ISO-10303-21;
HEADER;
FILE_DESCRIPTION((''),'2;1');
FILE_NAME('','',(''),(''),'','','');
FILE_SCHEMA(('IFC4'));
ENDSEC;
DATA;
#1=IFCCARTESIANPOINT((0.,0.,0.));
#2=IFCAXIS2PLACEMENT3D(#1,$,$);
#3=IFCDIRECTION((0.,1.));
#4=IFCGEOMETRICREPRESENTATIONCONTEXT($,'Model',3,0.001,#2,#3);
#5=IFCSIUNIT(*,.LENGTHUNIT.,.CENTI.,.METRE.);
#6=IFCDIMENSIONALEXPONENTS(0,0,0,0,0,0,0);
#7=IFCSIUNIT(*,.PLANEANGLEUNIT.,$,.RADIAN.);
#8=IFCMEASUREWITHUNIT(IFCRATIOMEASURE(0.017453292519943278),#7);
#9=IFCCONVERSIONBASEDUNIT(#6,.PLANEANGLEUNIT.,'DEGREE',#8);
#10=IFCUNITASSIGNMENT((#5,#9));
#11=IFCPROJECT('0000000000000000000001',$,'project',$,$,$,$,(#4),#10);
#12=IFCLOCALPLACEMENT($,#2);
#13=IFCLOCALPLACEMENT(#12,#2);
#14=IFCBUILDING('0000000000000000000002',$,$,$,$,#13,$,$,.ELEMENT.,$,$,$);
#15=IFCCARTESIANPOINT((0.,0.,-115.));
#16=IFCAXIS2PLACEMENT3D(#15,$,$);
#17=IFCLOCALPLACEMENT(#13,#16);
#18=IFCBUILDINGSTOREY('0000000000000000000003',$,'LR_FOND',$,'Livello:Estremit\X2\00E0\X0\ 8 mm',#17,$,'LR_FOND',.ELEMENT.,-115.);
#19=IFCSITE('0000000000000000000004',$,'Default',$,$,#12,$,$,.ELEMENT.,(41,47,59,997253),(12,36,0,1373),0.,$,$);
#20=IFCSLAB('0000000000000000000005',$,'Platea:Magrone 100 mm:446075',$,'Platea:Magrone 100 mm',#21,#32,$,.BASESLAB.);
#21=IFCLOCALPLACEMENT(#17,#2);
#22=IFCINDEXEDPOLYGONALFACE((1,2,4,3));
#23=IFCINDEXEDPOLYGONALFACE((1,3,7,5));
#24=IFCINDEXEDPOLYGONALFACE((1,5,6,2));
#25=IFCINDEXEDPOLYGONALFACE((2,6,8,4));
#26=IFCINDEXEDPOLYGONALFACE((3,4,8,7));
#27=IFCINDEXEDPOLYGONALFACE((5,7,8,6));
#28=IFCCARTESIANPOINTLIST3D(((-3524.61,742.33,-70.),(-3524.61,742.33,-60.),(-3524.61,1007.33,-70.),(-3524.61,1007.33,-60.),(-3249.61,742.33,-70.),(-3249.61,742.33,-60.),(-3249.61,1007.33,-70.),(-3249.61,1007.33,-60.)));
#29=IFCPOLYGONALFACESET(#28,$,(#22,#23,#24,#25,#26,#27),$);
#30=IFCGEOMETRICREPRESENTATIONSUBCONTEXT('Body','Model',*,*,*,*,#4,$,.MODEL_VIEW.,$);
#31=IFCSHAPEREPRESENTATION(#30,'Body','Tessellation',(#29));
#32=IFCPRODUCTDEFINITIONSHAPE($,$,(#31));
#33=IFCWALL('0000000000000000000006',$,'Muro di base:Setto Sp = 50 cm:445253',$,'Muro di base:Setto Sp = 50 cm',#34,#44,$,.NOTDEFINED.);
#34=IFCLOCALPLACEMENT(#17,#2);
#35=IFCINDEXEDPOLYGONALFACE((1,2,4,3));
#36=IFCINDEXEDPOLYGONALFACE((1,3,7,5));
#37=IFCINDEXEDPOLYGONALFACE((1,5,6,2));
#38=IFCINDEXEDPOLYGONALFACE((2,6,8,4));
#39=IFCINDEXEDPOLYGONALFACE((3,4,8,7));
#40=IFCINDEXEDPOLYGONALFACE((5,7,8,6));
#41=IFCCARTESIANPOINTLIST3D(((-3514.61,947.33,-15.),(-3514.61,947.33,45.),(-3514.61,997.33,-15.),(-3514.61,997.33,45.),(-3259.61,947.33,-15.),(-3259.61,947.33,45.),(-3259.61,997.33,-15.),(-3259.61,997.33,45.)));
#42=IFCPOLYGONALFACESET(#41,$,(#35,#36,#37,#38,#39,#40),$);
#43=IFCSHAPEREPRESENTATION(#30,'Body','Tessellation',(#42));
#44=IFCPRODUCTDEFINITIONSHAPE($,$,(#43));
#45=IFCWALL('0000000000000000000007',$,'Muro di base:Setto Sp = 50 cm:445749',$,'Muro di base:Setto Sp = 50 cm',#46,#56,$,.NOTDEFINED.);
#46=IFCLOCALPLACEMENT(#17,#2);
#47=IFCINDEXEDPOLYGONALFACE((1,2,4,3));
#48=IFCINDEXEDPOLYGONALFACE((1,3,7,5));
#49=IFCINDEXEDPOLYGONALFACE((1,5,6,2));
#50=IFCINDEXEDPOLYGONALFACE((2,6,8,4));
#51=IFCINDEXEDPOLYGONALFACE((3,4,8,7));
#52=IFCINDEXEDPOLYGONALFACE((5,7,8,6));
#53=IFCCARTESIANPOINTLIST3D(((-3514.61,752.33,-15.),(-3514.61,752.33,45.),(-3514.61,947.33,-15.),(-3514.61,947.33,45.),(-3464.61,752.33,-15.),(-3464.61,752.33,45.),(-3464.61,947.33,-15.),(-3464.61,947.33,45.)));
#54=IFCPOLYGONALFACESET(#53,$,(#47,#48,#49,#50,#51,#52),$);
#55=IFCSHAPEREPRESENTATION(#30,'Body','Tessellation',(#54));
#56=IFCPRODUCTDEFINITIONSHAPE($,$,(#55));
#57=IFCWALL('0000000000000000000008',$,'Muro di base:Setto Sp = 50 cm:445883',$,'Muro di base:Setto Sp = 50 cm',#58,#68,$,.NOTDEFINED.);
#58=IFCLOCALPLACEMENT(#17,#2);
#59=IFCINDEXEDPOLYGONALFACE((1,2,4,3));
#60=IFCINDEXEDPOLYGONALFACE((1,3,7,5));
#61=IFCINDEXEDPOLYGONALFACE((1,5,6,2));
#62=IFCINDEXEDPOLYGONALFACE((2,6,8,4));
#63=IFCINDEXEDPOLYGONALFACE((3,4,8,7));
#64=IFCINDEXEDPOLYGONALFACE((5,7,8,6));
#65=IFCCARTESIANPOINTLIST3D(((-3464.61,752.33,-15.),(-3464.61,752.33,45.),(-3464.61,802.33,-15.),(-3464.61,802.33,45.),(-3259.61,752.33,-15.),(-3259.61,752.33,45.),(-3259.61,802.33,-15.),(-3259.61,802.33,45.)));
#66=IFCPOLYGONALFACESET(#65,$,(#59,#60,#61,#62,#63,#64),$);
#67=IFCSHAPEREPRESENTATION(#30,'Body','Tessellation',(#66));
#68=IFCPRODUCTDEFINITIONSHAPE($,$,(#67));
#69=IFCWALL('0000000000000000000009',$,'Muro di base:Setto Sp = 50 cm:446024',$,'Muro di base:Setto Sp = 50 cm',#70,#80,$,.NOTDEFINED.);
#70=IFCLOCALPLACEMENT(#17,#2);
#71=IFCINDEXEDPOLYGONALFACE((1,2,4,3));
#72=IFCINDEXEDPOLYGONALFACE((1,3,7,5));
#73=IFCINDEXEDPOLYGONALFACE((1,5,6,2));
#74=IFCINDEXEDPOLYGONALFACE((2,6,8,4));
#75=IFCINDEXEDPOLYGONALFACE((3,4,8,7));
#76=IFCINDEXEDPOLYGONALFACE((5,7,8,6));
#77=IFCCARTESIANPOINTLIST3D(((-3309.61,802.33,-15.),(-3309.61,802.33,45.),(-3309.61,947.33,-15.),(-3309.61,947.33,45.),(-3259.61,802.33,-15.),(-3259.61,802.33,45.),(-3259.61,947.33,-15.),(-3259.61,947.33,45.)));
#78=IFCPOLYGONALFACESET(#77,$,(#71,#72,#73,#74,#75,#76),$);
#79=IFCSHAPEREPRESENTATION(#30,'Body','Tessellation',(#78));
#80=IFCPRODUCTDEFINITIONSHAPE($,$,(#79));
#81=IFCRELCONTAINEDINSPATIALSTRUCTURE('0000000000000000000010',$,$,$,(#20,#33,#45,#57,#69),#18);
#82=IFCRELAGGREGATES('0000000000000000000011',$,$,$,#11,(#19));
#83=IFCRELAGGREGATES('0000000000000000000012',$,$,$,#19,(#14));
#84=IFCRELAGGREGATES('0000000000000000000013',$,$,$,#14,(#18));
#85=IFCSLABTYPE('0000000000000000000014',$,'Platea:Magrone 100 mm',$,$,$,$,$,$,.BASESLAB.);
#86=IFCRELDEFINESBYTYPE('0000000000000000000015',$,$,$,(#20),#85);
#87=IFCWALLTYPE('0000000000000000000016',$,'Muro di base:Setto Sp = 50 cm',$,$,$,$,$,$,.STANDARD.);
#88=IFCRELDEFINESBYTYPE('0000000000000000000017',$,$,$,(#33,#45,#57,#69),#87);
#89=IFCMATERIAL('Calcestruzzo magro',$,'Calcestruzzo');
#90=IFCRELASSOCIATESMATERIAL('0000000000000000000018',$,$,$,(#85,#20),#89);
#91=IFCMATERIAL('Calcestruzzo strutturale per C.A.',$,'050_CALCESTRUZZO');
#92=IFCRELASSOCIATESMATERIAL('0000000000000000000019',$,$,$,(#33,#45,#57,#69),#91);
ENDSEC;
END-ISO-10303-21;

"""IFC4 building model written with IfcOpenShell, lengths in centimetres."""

from ifc_helpers import new_model, entity, si_unit, converted_unit, direction, frame, origin, place, context, subcontext, project, spatial, indexed_curve, outline, extrude, material, type_object, element, save


model = new_model("IFC4")

# Units and contexts
model_context = context("Model", 3, precision=0.001, world=origin(), true_north=direction((0.0, 1.0)))
body_context = subcontext(model_context, "Body", "Model", "MODEL_VIEW")
ifc_project = project(units=[si_unit("LENGTHUNIT", "METRE", prefix="CENTI"), converted_unit("PLANEANGLEUNIT", "DEGREE", entity("IfcRatioMeasure", 0.017453292519943278), si_unit("PLANEANGLEUNIT", "RADIAN"), dimensions=[0, 0, 0, 0, 0, 0, 0])], contexts=[model_context])

# Site, building, storey
site_placement = place(None, origin())
site = spatial("IfcSite", under=ifc_project, at=site_placement, Name="Default", CompositionType="ELEMENT", RefLatitude=(41, 47, 59, 997253), RefLongitude=(12, 36, 0, 1373), RefElevation=0.0)
building_placement = place(site_placement, origin())
building = spatial("IfcBuilding", under=site, at=building_placement, CompositionType="ELEMENT")
storey_placement = place(building_placement, frame((0.0, 0.0, -115.0)))
storey = spatial("IfcBuildingStorey", under=building, at=storey_placement, Name="LR_FOND", ObjectType="Livello:Estremità 8 mm", LongName="LR_FOND", CompositionType="ELEMENT", Elevation=-115.0)

# Slab
ifc_material_1 = material(Name="Calcestruzzo magro", Category="Calcestruzzo")
slab_type_1 = type_object("IfcSlabType", Name="Platea:Magrone 100 mm", PredefinedType="BASESLAB", material=ifc_material_1)
slab_1_placement = place(storey_placement, origin())
element("IfcSlab", 1, at=slab_1_placement, inside=storey, type_object=slab_type_1, material=ifc_material_1, Name="Platea:Magrone 100 mm:446075", ObjectType="Platea:Magrone 100 mm", PredefinedType="BASESLAB", context=body_context, shape_type="SweptSolid", body=[
    extrude(outline(indexed_curve([(-132.5, -137.5), (132.5, -137.5), (132.5, 137.5), (-132.5, 137.5), (-132.5, -137.5)], self_intersect=False)), frame((-3387.11, 874.83, -60.0), z_axis=(0.0, 0.0, -1.0), x_axis=(0.0, 1.0, 0.0)), (0.0, 0.0, 1.0), 10.0),
])

# Walls
ifc_material_2 = material(Name="Calcestruzzo strutturale per C.A.", Category="050_CALCESTRUZZO")
wall_type = type_object("IfcWallType", Name="Muro di base:Setto Sp = 50 cm", PredefinedType="STANDARD")
wall_1_placement = place(storey_placement, frame((-3514.61, 972.33, -15.0)))
element("IfcWall", 2, at=wall_1_placement, inside=storey, type_object=wall_type, material=ifc_material_2, Name="Muro di base:Setto Sp = 50 cm:445253", ObjectType="Muro di base:Setto Sp = 50 cm", PredefinedType="NOTDEFINED", context=body_context, shape_type="SweptSolid", body=[
    extrude(outline(indexed_curve([(255.0, 25.0), (0.0, 25.0), (0.0, -25.0), (255.0, -25.0), (255.0, 25.0)], self_intersect=False)), origin(), (0.0, 0.0, 1.0), 60.0),
])
wall_2_placement = place(storey_placement, frame((-3489.61, 947.33, -15.0), z_axis=(0.0, 0.0, 1.0), x_axis=(0.0, -1.0, 0.0)))
element("IfcWall", 3, at=wall_2_placement, inside=storey, type_object=wall_type, material=ifc_material_2, Name="Muro di base:Setto Sp = 50 cm:445749", ObjectType="Muro di base:Setto Sp = 50 cm", PredefinedType="NOTDEFINED", context=body_context, shape_type="SweptSolid", body=[
    extrude(outline(indexed_curve([(195.0, 25.0), (0.0, 25.0), (0.0, -25.0), (195.0, -25.0), (195.0, 25.0)], self_intersect=False)), origin(), (0.0, 0.0, 1.0), 60.0),
])
wall_3_placement = place(storey_placement, frame((-3464.61, 777.33, -15.0)))
element("IfcWall", 4, at=wall_3_placement, inside=storey, type_object=wall_type, material=ifc_material_2, Name="Muro di base:Setto Sp = 50 cm:445883", ObjectType="Muro di base:Setto Sp = 50 cm", PredefinedType="NOTDEFINED", context=body_context, shape_type="SweptSolid", body=[
    extrude(outline(indexed_curve([(205.0, 25.0), (0.0, 25.0), (0.0, -25.0), (205.0, -25.0), (205.0, 25.0)], self_intersect=False)), origin(), (0.0, 0.0, 1.0), 60.0),
])
wall_4_placement = place(storey_placement, frame((-3284.61, 802.33, -15.0), z_axis=(0.0, 0.0, 1.0), x_axis=(0.0, 1.0, 0.0)))
element("IfcWall", 5, at=wall_4_placement, inside=storey, type_object=wall_type, material=ifc_material_2, Name="Muro di base:Setto Sp = 50 cm:446024", ObjectType="Muro di base:Setto Sp = 50 cm", PredefinedType="NOTDEFINED", context=body_context, shape_type="SweptSolid", body=[
    extrude(outline(indexed_curve([(145.0, 25.0), (0.0, 25.0), (0.0, -25.0), (145.0, -25.0), (145.0, 25.0)], self_intersect=False)), origin(), (0.0, 0.0, 1.0), 60.0),
])

save(model, "model.ifc")
